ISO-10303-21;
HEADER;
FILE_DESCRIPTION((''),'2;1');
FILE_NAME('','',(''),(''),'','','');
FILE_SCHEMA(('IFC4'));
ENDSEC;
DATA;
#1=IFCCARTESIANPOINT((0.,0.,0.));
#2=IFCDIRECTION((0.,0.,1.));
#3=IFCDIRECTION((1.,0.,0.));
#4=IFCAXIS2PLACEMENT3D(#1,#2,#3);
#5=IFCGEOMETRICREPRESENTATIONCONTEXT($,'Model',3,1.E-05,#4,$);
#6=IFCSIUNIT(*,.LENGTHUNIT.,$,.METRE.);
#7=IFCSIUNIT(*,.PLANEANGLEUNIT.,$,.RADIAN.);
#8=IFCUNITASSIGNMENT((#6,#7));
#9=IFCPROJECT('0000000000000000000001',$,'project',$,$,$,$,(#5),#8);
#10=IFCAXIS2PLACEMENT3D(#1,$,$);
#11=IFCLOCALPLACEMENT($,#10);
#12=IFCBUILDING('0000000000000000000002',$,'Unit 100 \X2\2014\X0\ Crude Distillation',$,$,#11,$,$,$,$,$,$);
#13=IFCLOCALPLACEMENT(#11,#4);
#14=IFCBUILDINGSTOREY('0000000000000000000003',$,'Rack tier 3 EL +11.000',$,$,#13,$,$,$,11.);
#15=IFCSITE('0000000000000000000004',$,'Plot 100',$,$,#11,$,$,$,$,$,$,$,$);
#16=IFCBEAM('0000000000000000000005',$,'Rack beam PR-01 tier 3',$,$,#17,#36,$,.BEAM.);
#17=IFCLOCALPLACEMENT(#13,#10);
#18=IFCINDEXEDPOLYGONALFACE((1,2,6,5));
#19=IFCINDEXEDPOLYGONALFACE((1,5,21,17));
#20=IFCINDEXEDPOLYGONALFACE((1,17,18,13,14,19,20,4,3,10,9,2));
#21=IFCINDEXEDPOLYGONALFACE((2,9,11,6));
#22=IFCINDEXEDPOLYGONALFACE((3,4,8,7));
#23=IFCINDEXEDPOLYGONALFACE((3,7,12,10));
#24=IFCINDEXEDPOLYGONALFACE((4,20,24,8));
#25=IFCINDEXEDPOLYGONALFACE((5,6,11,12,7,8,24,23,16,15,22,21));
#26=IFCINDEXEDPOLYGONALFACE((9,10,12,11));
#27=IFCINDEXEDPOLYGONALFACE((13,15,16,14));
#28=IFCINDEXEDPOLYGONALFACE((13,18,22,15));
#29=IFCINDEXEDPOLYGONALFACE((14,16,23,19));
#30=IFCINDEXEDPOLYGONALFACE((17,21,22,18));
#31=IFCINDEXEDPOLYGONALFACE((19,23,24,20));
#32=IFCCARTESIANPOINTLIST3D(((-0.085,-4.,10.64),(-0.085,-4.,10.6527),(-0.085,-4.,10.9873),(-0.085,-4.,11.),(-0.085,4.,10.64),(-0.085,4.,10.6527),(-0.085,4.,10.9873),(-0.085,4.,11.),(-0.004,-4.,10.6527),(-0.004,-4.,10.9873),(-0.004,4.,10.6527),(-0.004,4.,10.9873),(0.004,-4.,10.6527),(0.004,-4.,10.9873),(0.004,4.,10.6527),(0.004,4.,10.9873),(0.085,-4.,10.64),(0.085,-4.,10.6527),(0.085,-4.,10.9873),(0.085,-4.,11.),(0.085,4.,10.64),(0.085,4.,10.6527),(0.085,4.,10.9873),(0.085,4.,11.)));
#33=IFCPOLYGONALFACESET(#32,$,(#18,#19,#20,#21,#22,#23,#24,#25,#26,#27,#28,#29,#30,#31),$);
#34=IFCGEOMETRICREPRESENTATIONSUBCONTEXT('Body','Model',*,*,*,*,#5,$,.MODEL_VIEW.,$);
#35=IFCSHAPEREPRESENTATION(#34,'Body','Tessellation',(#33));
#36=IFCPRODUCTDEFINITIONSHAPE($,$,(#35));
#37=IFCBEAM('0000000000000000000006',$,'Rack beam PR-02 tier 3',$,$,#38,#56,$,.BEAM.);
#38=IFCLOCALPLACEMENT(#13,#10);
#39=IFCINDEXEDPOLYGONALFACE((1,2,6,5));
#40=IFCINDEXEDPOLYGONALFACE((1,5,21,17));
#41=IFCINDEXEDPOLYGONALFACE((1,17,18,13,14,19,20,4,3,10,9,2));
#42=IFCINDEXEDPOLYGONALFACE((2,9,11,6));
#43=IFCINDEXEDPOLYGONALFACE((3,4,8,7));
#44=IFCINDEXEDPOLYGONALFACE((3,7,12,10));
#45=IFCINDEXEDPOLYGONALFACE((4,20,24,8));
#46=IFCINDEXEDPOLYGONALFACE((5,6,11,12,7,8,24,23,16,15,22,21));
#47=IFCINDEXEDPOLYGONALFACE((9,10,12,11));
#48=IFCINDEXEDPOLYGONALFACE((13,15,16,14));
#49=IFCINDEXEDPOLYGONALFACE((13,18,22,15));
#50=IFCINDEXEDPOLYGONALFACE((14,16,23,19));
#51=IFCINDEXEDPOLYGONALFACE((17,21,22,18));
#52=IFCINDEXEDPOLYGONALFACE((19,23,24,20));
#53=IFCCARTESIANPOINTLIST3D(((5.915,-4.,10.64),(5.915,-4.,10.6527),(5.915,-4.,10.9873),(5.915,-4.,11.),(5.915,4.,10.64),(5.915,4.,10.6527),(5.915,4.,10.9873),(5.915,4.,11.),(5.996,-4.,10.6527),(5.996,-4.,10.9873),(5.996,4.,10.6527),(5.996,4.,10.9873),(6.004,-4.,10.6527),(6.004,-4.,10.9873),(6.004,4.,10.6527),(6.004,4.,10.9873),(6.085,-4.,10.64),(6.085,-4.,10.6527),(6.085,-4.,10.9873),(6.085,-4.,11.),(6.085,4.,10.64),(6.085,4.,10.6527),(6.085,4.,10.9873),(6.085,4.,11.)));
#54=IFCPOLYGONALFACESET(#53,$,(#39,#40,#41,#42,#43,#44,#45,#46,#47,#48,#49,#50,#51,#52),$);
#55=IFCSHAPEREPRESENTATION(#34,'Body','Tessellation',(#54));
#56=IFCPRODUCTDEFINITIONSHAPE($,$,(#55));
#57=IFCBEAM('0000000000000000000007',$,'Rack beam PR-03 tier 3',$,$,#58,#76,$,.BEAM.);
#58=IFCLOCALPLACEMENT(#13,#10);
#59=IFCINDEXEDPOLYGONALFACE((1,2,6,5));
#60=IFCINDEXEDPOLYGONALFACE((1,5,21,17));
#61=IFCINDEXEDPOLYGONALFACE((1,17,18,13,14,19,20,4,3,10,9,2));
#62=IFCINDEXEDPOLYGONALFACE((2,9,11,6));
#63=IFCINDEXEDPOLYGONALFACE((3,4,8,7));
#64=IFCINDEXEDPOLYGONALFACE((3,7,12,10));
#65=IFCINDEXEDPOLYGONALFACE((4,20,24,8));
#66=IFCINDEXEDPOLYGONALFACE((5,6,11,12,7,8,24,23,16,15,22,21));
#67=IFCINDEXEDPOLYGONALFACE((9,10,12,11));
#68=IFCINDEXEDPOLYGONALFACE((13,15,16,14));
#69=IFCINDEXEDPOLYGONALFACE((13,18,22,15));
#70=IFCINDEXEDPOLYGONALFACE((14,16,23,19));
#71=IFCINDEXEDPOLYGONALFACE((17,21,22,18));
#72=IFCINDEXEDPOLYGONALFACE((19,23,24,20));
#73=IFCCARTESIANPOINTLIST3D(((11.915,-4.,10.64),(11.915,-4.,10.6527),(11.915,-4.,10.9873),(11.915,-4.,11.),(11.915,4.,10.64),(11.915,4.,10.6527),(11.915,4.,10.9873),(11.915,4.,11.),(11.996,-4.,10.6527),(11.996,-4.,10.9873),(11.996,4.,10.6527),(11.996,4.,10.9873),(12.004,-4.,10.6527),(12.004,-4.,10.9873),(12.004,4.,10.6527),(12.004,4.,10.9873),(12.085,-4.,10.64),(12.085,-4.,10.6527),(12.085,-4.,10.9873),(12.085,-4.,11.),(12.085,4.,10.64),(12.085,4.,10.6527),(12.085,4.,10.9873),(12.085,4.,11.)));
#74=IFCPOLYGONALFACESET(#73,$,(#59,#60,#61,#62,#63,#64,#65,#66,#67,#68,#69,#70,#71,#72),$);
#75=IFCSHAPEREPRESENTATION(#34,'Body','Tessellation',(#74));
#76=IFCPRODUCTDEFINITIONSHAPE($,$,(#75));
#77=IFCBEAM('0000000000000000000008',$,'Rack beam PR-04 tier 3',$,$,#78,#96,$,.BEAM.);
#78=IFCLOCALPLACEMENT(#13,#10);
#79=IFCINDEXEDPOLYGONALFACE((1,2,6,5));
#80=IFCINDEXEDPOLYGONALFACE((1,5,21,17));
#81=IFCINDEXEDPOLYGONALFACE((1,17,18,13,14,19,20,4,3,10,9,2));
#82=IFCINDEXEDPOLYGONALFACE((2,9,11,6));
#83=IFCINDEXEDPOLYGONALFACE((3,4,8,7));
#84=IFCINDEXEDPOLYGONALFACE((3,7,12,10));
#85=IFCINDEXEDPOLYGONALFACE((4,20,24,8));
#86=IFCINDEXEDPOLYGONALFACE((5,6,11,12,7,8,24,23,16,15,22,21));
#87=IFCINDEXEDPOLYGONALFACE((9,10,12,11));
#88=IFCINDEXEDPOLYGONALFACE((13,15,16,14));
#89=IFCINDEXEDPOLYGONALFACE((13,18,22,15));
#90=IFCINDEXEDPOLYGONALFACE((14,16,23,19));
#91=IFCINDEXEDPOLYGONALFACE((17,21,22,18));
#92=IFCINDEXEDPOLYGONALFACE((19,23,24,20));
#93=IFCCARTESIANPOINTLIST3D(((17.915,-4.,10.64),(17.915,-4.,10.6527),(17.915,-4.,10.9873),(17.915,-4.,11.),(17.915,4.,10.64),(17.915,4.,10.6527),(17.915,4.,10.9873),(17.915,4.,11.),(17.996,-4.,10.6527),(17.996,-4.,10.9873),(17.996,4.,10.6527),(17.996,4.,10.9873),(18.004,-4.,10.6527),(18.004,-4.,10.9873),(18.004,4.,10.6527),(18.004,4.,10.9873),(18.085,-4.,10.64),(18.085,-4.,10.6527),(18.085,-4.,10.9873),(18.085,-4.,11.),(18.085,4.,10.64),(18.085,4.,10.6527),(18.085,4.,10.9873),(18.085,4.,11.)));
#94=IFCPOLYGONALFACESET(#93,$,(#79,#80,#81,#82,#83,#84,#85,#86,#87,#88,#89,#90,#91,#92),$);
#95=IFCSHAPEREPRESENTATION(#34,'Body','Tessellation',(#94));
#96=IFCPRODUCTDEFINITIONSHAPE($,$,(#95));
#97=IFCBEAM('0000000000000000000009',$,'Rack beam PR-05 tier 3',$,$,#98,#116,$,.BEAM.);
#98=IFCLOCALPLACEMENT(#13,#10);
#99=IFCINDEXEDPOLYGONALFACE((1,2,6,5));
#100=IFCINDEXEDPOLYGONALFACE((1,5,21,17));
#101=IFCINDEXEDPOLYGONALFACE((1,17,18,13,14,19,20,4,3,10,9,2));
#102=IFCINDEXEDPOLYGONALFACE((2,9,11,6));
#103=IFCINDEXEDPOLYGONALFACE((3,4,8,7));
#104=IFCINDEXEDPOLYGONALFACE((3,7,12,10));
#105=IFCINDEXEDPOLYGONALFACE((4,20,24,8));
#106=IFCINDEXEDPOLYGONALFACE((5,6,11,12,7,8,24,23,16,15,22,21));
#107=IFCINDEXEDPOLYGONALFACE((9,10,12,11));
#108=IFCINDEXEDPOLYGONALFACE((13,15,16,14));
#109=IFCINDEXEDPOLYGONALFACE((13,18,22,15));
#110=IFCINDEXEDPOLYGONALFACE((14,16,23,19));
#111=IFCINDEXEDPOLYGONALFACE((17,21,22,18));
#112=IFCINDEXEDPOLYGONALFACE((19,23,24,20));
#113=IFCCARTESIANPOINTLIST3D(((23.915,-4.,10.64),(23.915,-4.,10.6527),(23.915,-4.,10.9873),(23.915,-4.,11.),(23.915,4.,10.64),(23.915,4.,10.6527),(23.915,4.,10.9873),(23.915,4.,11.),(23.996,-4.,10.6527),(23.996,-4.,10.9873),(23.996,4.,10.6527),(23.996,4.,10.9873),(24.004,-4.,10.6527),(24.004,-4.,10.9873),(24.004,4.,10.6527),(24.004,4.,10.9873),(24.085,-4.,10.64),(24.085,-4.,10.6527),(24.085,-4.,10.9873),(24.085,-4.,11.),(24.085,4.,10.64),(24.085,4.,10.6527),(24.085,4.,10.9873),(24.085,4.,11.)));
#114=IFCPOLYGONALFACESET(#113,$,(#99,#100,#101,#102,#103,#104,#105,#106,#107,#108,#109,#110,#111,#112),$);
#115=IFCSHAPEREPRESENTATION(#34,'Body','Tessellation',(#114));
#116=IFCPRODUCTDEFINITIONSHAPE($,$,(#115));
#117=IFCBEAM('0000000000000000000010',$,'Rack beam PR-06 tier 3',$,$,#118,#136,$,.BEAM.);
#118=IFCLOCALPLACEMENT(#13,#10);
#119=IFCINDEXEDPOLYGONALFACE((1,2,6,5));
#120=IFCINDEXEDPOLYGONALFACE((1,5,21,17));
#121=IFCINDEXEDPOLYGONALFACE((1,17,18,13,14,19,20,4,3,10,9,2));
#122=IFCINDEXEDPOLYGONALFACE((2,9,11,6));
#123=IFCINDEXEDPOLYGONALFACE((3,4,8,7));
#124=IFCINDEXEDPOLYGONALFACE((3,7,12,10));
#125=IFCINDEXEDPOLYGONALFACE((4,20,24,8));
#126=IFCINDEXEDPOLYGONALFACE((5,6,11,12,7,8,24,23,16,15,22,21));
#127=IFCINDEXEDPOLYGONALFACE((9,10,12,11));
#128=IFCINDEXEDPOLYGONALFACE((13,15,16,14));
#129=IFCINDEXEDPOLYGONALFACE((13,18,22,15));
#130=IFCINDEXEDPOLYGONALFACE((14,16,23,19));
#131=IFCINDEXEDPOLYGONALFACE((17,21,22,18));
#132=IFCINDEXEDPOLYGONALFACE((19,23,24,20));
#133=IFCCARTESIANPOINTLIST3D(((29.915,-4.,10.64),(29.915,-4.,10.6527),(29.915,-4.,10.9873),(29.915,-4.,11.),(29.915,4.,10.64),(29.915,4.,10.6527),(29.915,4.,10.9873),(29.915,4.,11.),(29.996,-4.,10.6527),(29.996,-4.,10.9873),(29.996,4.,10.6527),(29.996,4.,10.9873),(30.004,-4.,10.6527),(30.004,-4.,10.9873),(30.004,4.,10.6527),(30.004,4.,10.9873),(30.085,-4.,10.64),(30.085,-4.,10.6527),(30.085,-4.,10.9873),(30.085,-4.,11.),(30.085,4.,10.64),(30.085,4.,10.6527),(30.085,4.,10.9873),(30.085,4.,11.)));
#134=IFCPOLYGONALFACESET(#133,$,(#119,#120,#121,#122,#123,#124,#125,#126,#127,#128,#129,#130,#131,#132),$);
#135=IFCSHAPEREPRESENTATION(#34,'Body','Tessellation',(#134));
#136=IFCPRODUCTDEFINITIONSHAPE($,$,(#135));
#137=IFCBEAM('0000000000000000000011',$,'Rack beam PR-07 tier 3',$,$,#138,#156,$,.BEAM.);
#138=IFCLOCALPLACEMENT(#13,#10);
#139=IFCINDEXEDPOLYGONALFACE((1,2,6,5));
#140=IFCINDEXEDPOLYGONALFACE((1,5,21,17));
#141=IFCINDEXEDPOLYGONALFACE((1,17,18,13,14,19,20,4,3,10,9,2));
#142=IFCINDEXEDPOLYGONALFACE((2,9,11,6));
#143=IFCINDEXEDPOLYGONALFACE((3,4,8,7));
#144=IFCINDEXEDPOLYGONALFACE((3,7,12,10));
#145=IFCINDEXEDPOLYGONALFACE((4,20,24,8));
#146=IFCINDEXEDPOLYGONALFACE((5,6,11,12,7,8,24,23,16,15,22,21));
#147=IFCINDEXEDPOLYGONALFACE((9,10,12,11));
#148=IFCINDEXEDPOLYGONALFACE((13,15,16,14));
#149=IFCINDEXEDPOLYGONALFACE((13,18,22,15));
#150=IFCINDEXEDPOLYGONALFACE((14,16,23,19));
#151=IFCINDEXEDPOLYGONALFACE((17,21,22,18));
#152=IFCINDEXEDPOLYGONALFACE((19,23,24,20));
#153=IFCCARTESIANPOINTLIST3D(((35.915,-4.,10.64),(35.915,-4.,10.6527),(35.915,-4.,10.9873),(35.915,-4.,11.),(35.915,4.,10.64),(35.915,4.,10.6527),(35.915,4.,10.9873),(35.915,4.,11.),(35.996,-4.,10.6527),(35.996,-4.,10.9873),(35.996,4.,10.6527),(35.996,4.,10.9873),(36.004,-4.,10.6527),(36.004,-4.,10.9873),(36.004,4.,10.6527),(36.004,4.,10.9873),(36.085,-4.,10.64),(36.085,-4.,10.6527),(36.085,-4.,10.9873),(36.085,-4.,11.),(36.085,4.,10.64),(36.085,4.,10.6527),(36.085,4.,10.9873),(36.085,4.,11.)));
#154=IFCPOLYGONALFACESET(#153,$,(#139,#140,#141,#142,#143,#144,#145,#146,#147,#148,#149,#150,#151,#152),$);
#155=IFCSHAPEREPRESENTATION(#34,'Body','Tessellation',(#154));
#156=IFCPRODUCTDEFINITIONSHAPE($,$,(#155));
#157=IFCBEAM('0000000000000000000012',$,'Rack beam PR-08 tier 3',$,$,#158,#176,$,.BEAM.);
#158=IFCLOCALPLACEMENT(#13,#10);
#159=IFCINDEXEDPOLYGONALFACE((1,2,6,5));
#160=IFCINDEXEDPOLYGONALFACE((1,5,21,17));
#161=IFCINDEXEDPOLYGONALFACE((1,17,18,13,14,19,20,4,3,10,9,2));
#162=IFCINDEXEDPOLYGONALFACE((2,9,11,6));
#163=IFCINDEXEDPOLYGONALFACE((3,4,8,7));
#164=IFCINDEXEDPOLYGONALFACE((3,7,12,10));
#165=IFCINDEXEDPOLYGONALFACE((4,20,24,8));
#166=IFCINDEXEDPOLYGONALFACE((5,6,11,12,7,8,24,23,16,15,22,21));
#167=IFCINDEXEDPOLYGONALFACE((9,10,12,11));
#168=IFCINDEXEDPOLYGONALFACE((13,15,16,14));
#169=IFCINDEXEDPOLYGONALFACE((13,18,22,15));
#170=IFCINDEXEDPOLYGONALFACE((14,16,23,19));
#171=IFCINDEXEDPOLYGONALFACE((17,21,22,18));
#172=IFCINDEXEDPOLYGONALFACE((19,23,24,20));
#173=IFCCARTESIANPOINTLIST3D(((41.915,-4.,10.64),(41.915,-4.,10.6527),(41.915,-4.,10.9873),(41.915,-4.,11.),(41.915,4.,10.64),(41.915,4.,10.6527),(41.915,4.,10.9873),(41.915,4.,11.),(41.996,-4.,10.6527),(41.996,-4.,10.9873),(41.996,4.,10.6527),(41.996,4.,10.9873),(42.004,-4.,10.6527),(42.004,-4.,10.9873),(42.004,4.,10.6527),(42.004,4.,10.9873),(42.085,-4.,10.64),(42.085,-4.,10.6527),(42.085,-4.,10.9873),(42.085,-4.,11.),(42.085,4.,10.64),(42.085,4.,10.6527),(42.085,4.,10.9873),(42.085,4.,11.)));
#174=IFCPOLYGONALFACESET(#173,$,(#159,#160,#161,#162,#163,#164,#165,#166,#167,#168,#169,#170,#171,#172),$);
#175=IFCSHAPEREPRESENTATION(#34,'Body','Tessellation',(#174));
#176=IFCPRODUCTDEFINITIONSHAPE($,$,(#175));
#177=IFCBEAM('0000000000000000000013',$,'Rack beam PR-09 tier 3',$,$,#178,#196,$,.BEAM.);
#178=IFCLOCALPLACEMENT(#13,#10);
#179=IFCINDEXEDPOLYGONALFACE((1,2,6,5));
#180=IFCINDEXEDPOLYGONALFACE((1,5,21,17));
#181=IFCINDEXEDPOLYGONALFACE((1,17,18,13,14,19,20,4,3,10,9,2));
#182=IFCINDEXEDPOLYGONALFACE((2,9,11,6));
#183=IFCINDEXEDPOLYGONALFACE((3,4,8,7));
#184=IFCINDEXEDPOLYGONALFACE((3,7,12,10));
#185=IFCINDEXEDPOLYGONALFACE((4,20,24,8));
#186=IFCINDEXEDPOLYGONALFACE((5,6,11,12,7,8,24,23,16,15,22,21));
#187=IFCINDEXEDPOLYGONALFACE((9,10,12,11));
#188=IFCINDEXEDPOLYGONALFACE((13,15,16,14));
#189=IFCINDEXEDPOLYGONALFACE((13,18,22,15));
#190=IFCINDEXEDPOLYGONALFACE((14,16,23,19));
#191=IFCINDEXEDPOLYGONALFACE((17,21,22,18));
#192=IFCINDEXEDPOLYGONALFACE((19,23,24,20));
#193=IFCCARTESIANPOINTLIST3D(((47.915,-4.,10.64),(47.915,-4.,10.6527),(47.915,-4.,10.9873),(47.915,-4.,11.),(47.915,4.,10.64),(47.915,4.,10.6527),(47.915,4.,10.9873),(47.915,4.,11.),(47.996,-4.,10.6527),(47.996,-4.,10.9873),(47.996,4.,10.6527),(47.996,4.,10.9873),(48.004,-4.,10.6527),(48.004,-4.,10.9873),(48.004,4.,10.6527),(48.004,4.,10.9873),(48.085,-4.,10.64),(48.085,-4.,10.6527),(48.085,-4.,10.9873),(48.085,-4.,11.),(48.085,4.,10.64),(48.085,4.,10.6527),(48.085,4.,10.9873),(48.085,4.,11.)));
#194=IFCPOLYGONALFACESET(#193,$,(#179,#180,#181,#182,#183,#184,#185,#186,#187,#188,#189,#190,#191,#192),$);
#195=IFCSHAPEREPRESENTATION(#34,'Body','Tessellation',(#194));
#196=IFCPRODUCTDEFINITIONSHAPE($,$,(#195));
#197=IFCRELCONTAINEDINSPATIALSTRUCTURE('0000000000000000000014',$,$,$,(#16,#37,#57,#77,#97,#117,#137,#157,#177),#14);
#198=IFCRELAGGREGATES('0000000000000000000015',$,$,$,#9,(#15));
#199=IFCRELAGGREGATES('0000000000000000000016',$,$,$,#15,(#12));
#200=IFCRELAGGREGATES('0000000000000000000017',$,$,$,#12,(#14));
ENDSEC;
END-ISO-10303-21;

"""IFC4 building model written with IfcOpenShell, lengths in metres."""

from ifc_helpers import new_model, si_unit, frame, origin, origin_with_axes, origin_2d, place, context, subcontext, project, spatial, i_section, extrude, element, save


model = new_model("IFC4")

# Units and contexts
model_context = context("Model", 3, precision=1e-05, world=origin_with_axes())
body_context = subcontext(model_context, "Body", "Model", "MODEL_VIEW")
ifc_project = project(units=[si_unit("LENGTHUNIT", "METRE"), si_unit("PLANEANGLEUNIT", "RADIAN")], contexts=[model_context])

# Site, building, storey
placement = place(None, origin())
site = spatial("IfcSite", under=ifc_project, at=placement, Name="Plot 100")
building = spatial("IfcBuilding", under=site, at=placement, Name="Unit 100 — Crude Distillation")
storey_placement = place(placement, origin_with_axes())
storey = spatial("IfcBuildingStorey", under=building, at=storey_placement, Name="Rack tier 3 EL +11.000", Elevation=11.0)

# Beams
beam_1_placement = place(storey_placement, origin_with_axes())
element("IfcBeam", 1, at=beam_1_placement, inside=storey, Name="Rack beam PR-01 tier 3", PredefinedType="BEAM", context=body_context, shape_type="SweptSolid", body=[
    extrude(i_section(OverallWidth=0.17, OverallDepth=0.36, WebThickness=0.008, FlangeThickness=0.0127, at=origin_2d()), frame((0.0, -4.0, 10.82), z_axis=(0.0, 1.0, 0.0), x_axis=(-1.0, 0.0, 0.0)), (0.0, 0.0, 1.0), 8.0),
])
beam_2_placement = place(storey_placement, origin_with_axes())
element("IfcBeam", 2, at=beam_2_placement, inside=storey, Name="Rack beam PR-02 tier 3", PredefinedType="BEAM", context=body_context, shape_type="SweptSolid", body=[
    extrude(i_section(OverallWidth=0.17, OverallDepth=0.36, WebThickness=0.008, FlangeThickness=0.0127, at=origin_2d()), frame((6.0, -4.0, 10.82), z_axis=(0.0, 1.0, 0.0), x_axis=(-1.0, 0.0, 0.0)), (0.0, 0.0, 1.0), 8.0),
])
beam_3_placement = place(storey_placement, origin_with_axes())
element("IfcBeam", 3, at=beam_3_placement, inside=storey, Name="Rack beam PR-03 tier 3", PredefinedType="BEAM", context=body_context, shape_type="SweptSolid", body=[
    extrude(i_section(OverallWidth=0.17, OverallDepth=0.36, WebThickness=0.008, FlangeThickness=0.0127, at=origin_2d()), frame((12.0, -4.0, 10.82), z_axis=(0.0, 1.0, 0.0), x_axis=(-1.0, 0.0, 0.0)), (0.0, 0.0, 1.0), 8.0),
])
beam_4_placement = place(storey_placement, origin_with_axes())
element("IfcBeam", 4, at=beam_4_placement, inside=storey, Name="Rack beam PR-04 tier 3", PredefinedType="BEAM", context=body_context, shape_type="SweptSolid", body=[
    extrude(i_section(OverallWidth=0.17, OverallDepth=0.36, WebThickness=0.008, FlangeThickness=0.0127, at=origin_2d()), frame((18.0, -4.0, 10.82), z_axis=(0.0, 1.0, 0.0), x_axis=(-1.0, 0.0, 0.0)), (0.0, 0.0, 1.0), 8.0),
])
beam_5_placement = place(storey_placement, origin_with_axes())
element("IfcBeam", 5, at=beam_5_placement, inside=storey, Name="Rack beam PR-05 tier 3", PredefinedType="BEAM", context=body_context, shape_type="SweptSolid", body=[
    extrude(i_section(OverallWidth=0.17, OverallDepth=0.36, WebThickness=0.008, FlangeThickness=0.0127, at=origin_2d()), frame((24.0, -4.0, 10.82), z_axis=(0.0, 1.0, 0.0), x_axis=(-1.0, 0.0, 0.0)), (0.0, 0.0, 1.0), 8.0),
])
beam_6_placement = place(storey_placement, origin_with_axes())
element("IfcBeam", 6, at=beam_6_placement, inside=storey, Name="Rack beam PR-06 tier 3", PredefinedType="BEAM", context=body_context, shape_type="SweptSolid", body=[
    extrude(i_section(OverallWidth=0.17, OverallDepth=0.36, WebThickness=0.008, FlangeThickness=0.0127, at=origin_2d()), frame((30.0, -4.0, 10.82), z_axis=(0.0, 1.0, 0.0), x_axis=(-1.0, 0.0, 0.0)), (0.0, 0.0, 1.0), 8.0),
])
beam_7_placement = place(storey_placement, origin_with_axes())
element("IfcBeam", 7, at=beam_7_placement, inside=storey, Name="Rack beam PR-07 tier 3", PredefinedType="BEAM", context=body_context, shape_type="SweptSolid", body=[
    extrude(i_section(OverallWidth=0.17, OverallDepth=0.36, WebThickness=0.008, FlangeThickness=0.0127, at=origin_2d()), frame((36.0, -4.0, 10.82), z_axis=(0.0, 1.0, 0.0), x_axis=(-1.0, 0.0, 0.0)), (0.0, 0.0, 1.0), 8.0),
])
beam_8_placement = place(storey_placement, origin_with_axes())
element("IfcBeam", 8, at=beam_8_placement, inside=storey, Name="Rack beam PR-08 tier 3", PredefinedType="BEAM", context=body_context, shape_type="SweptSolid", body=[
    extrude(i_section(OverallWidth=0.17, OverallDepth=0.36, WebThickness=0.008, FlangeThickness=0.0127, at=origin_2d()), frame((42.0, -4.0, 10.82), z_axis=(0.0, 1.0, 0.0), x_axis=(-1.0, 0.0, 0.0)), (0.0, 0.0, 1.0), 8.0),
])
beam_9_placement = place(storey_placement, origin_with_axes())
element("IfcBeam", 9, at=beam_9_placement, inside=storey, Name="Rack beam PR-09 tier 3", PredefinedType="BEAM", context=body_context, shape_type="SweptSolid", body=[
    extrude(i_section(OverallWidth=0.17, OverallDepth=0.36, WebThickness=0.008, FlangeThickness=0.0127, at=origin_2d()), frame((48.0, -4.0, 10.82), z_axis=(0.0, 1.0, 0.0), x_axis=(-1.0, 0.0, 0.0)), (0.0, 0.0, 1.0), 8.0),
])

save(model, "model.ifc")
